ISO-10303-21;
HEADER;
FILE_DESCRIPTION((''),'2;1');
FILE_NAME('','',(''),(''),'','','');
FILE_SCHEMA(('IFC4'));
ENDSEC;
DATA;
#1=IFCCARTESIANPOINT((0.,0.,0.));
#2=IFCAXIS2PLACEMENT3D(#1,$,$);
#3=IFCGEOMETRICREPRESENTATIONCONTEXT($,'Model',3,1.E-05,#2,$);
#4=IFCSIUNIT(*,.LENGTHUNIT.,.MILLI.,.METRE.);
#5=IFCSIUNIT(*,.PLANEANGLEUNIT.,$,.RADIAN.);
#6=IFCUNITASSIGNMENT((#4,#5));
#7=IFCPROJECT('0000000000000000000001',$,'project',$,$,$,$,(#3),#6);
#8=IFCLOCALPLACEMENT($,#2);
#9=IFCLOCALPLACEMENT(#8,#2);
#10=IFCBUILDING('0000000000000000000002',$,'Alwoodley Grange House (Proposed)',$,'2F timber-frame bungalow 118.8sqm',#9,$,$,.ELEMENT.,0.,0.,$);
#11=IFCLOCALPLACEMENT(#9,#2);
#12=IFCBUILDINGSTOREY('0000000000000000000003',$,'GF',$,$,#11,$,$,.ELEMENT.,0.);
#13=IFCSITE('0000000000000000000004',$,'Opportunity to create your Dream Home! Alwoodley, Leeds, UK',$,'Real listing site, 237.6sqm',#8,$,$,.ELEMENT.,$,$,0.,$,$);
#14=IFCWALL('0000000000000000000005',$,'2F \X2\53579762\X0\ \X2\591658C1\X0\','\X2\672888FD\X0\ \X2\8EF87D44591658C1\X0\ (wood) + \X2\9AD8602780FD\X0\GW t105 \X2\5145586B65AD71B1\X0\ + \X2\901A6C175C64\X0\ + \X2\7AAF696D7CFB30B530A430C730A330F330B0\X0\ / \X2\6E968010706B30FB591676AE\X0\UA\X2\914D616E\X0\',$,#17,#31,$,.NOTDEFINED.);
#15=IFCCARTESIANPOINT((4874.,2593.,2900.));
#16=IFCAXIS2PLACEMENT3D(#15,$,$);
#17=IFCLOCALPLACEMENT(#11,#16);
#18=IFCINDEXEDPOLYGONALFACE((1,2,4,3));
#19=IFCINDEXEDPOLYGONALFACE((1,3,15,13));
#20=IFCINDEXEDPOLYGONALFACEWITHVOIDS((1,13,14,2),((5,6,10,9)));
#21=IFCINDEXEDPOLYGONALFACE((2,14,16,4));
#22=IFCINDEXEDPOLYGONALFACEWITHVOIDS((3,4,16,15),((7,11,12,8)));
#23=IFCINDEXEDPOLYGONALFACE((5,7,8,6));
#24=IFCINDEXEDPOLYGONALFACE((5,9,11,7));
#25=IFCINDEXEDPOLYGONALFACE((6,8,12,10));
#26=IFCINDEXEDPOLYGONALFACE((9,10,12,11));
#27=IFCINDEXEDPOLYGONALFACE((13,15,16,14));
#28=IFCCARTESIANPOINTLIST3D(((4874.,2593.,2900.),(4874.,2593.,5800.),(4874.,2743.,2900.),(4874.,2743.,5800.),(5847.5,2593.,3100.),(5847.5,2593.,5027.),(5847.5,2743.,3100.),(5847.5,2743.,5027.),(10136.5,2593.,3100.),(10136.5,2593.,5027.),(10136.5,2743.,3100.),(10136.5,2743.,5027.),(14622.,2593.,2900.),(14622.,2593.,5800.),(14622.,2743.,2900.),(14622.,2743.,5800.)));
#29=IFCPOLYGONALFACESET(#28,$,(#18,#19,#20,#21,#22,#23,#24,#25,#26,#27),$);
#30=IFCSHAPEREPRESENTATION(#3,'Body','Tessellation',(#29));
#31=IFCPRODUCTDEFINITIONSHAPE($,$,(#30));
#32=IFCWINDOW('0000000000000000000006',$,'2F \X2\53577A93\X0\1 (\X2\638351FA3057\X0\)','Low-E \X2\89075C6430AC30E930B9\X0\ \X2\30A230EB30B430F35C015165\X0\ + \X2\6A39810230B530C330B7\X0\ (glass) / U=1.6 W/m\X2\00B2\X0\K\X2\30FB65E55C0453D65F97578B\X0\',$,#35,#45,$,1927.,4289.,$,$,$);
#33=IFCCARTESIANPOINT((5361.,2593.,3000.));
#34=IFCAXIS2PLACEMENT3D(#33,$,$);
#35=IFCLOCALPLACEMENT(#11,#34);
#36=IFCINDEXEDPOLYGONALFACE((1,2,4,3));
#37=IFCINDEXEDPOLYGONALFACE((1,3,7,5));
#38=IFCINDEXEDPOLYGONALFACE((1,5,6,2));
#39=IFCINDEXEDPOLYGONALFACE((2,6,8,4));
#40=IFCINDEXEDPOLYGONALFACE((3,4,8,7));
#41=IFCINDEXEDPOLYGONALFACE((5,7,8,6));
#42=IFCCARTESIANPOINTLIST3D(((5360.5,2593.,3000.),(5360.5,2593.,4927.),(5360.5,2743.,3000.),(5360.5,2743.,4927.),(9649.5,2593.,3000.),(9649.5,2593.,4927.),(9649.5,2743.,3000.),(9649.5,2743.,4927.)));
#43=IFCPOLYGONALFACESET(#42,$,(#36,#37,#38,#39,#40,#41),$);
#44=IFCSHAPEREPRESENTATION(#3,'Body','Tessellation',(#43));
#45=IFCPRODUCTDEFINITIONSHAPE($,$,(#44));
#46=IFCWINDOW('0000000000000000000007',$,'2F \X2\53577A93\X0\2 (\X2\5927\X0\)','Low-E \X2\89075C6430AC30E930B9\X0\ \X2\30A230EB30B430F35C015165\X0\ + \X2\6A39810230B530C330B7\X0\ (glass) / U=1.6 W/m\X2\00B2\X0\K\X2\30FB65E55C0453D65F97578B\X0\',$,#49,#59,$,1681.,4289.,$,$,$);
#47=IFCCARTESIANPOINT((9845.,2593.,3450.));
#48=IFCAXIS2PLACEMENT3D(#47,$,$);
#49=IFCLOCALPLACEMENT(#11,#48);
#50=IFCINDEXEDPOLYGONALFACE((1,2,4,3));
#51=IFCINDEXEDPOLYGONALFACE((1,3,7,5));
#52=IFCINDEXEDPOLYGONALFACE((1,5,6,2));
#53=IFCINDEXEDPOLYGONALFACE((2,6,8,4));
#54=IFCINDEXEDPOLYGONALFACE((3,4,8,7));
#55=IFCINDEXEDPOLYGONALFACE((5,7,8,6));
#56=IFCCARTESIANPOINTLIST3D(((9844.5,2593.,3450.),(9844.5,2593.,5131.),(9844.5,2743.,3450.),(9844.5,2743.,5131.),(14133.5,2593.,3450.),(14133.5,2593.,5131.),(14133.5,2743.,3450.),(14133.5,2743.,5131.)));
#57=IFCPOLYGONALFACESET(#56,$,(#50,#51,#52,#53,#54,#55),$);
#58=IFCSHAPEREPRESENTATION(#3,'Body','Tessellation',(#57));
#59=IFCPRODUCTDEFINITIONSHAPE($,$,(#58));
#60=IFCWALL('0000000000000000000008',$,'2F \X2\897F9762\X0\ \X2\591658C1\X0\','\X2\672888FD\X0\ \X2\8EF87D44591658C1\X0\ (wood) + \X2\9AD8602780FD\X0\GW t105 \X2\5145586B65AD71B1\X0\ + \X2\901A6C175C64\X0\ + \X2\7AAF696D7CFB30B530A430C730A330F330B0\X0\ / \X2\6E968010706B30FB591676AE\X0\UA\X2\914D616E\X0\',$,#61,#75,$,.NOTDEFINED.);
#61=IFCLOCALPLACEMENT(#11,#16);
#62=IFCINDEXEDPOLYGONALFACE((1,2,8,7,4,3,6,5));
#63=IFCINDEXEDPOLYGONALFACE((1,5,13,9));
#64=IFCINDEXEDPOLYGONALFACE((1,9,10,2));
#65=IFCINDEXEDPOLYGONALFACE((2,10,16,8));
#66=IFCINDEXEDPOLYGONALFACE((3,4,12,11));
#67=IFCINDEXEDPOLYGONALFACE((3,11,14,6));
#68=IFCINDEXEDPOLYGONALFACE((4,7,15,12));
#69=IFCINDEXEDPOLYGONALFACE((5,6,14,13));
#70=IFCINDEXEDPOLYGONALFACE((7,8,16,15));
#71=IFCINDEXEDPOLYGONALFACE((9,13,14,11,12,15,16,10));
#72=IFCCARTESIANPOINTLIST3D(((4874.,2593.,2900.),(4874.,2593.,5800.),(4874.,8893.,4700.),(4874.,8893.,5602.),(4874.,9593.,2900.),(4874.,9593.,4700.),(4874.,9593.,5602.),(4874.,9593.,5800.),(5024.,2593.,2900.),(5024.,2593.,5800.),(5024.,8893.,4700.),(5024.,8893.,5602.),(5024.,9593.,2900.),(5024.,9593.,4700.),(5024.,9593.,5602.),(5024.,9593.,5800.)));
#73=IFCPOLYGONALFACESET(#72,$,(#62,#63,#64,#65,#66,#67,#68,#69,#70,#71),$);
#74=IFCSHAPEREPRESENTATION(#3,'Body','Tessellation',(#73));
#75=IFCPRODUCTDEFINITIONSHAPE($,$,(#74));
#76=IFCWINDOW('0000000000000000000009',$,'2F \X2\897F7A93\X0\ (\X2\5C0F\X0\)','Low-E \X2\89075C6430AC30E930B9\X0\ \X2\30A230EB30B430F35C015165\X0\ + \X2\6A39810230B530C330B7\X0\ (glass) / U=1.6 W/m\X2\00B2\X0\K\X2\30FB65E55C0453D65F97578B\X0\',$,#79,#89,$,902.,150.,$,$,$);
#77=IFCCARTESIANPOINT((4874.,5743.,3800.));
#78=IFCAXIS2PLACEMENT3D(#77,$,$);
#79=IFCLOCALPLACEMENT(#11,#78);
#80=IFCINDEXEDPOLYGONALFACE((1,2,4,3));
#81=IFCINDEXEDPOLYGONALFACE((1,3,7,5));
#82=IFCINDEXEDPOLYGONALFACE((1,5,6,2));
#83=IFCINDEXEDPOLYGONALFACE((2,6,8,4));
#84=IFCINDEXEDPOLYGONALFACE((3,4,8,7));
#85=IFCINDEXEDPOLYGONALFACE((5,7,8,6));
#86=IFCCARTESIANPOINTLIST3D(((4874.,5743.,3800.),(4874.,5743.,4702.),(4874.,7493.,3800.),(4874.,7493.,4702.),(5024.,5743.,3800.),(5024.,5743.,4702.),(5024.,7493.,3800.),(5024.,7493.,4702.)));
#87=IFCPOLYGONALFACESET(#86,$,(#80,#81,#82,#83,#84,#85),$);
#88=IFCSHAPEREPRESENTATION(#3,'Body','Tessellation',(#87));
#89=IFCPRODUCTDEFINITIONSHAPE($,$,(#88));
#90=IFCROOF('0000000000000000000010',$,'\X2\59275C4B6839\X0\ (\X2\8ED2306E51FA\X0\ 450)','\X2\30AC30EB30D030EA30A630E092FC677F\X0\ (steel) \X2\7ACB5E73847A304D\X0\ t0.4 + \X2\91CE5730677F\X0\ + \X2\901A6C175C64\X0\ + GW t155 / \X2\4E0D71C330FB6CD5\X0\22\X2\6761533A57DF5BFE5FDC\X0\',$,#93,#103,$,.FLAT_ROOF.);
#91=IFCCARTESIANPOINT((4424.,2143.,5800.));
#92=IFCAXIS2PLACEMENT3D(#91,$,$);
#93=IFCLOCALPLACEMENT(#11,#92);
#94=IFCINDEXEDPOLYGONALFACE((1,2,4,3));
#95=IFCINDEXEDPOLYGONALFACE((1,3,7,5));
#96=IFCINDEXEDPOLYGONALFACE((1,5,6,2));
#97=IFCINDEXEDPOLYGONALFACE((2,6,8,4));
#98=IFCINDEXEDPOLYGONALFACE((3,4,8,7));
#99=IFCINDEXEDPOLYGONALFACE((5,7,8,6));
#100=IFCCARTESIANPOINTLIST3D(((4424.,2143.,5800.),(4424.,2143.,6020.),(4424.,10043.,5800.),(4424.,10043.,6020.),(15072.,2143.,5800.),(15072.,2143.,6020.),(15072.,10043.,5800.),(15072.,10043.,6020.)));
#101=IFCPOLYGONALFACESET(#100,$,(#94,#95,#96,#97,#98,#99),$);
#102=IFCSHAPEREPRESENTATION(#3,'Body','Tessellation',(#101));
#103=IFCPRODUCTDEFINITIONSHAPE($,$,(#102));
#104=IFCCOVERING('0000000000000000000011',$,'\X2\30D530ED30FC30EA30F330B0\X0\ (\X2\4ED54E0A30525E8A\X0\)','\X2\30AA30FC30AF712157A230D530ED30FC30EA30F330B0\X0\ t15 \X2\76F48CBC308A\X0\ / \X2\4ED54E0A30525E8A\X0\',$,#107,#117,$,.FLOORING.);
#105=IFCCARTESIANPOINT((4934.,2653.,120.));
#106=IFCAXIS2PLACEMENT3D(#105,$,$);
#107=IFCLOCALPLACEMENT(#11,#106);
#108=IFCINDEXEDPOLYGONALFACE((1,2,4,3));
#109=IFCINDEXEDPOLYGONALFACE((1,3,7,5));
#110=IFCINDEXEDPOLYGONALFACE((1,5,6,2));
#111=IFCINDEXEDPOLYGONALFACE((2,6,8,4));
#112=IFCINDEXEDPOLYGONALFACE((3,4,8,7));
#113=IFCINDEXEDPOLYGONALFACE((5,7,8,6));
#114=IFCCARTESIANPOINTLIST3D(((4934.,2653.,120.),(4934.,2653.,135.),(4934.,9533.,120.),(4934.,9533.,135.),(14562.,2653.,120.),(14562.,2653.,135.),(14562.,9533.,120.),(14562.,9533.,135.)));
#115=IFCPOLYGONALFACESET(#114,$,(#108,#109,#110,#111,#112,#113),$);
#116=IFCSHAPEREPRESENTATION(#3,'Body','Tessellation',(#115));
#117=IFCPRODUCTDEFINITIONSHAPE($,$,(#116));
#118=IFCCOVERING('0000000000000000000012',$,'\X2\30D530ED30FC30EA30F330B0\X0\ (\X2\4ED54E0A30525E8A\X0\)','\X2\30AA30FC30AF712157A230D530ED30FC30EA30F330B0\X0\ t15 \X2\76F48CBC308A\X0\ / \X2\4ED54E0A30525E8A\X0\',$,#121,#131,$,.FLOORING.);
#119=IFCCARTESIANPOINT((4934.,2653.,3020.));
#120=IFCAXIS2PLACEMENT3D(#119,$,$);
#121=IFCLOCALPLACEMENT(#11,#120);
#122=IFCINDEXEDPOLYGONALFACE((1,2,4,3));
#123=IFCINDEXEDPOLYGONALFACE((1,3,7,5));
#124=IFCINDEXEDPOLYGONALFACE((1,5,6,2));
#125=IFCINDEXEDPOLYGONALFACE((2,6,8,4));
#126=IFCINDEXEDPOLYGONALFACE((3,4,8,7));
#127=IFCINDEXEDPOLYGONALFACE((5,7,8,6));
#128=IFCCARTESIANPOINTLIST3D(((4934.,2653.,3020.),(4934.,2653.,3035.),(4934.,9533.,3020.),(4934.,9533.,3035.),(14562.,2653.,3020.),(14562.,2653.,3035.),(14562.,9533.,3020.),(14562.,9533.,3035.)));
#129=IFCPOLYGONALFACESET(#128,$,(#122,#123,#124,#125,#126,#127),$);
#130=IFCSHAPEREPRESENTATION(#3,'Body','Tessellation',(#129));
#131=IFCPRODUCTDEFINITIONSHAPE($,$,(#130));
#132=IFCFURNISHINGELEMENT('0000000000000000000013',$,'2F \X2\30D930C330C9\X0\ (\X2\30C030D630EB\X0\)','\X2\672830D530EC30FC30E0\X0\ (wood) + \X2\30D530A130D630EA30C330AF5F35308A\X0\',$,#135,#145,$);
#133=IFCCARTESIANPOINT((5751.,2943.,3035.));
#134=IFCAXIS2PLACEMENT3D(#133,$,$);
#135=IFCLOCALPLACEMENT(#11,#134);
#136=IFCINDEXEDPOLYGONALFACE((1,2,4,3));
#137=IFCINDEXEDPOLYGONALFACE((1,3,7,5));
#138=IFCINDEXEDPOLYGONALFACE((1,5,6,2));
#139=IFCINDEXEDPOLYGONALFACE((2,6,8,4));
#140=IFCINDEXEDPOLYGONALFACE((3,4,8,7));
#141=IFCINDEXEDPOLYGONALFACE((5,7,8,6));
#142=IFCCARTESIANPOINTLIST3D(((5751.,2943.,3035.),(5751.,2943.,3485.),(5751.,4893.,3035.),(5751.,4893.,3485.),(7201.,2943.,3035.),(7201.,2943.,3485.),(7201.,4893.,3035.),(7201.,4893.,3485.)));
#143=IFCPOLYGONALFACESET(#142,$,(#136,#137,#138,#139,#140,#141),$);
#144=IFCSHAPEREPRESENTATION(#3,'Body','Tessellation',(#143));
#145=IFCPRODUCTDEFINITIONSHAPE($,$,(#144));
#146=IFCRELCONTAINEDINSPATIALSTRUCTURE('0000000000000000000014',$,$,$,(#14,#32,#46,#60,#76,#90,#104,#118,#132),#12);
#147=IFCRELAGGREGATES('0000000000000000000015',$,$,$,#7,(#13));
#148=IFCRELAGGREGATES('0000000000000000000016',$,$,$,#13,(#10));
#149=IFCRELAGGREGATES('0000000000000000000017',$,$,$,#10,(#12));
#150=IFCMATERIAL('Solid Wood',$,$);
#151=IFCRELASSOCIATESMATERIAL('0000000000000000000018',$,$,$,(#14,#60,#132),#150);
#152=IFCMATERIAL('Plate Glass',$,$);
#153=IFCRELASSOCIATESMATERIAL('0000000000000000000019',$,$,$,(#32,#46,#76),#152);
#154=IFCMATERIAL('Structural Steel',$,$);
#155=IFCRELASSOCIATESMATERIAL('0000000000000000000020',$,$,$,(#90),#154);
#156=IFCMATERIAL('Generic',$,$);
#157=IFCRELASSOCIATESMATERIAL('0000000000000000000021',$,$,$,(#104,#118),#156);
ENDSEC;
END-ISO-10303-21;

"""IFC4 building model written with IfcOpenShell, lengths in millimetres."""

from ifc_helpers import new_model, si_unit, frame, frame_2d, origin, place, context, project, spatial, rectangle, extrude, material, element, fill, save


model = new_model("IFC4")

# Units and contexts
model_context = context("Model", 3, precision=1e-05, world=origin())
ifc_project = project(units=[si_unit("LENGTHUNIT", "METRE", prefix="MILLI"), si_unit("PLANEANGLEUNIT", "RADIAN")], contexts=[model_context])

# Site, building, storey
site_placement = place(None, origin())
site = spatial("IfcSite", under=ifc_project, at=site_placement, Name="Opportunity to create your Dream Home! Alwoodley, Leeds, UK", ObjectType="Real listing site, 237.6sqm", CompositionType="ELEMENT", RefElevation=0.0)
building_placement = place(site_placement, origin())
building = spatial("IfcBuilding", under=site, at=building_placement, Name="Alwoodley Grange House (Proposed)", ObjectType="2F timber-frame bungalow 118.8sqm", CompositionType="ELEMENT", ElevationOfRefHeight=0.0, ElevationOfTerrain=0.0)
storey_placement = place(building_placement, origin())
storey = spatial("IfcBuildingStorey", under=building, at=storey_placement, Name="GF", CompositionType="ELEMENT", Elevation=0.0)

# Shared definitions
ifc_material_1 = material(Name="Solid Wood")

# Shared definitions
ifc_material_2 = material(Name="Plate Glass")

# Wall, openings, windows
wall_1_placement = place(storey_placement, frame((4874.0, 2593.0, 2900.0)))
wall_1 = element("IfcWall", 1, at=wall_1_placement, inside=storey, material=ifc_material_1, Name="2F 南面 外壁", Description="木製 軸組外壁 (wood) + 高性能GW t105 充填断熱 + 通気層 + 窯業系サイディング / 準耐火・外皮UA配慮", PredefinedType="NOTDEFINED", context=model_context, shape_type="SweptSolid", body=[
    extrude(rectangle(XDim=9748.0, YDim=150.0, at=frame_2d((4874.0, 75.0))), frame((4874.0, 2593.0, 2900.0)), (0.0, 0.0, 1.0), 2900.0),
])
opening_1_placement = place(storey_placement, frame((5361.0, 2593.0, 3000.0)))
opening_1 = element("IfcOpeningElement", 2, at=opening_1_placement, cuts=wall_1, PredefinedType="NOTDEFINED", context=model_context, shape_type="SweptSolid", body=[
    extrude(rectangle(XDim=4289.0, YDim=150.0, at=frame_2d((2144.0, 75.0))), frame((5361.0, 2593.0, 3000.0)), (0.0, 0.0, 1.0), 1927.0),
])
opening_2_placement = place(storey_placement, frame((9845.0, 2593.0, 3450.0)))
opening_2 = element("IfcOpeningElement", 3, at=opening_2_placement, cuts=wall_1, PredefinedType="NOTDEFINED", context=model_context, shape_type="SweptSolid", body=[
    extrude(rectangle(XDim=4289.0, YDim=150.0, at=frame_2d((2144.0, 75.0))), frame((9845.0, 2593.0, 3450.0)), (0.0, 0.0, 1.0), 1681.0),
])
window_1_placement = place(storey_placement, frame((5361.0, 2593.0, 3000.0)))
window_1 = element("IfcWindow", 4, at=window_1_placement, inside=storey, material=ifc_material_2, Name="2F 南窓1 (掃出し)", Description="Low-E 複層ガラス アルゴン封入 + 樹脂サッシ (glass) / U=1.6 W/m²K・日射取得型", OverallHeight=1927.0, OverallWidth=4289.0, context=model_context, shape_type="SweptSolid", body=[
    extrude(rectangle(XDim=4289.0, YDim=150.0, at=frame_2d((2144.0, 75.0))), frame((5361.0, 2593.0, 3000.0)), (0.0, 0.0, 1.0), 1927.0),
])
fill(opening_1, window_1)
window_2_placement = place(storey_placement, frame((9845.0, 2593.0, 3450.0)))
window_2 = element("IfcWindow", 5, at=window_2_placement, inside=storey, material=ifc_material_2, Name="2F 南窓2 (大)", Description="Low-E 複層ガラス アルゴン封入 + 樹脂サッシ (glass) / U=1.6 W/m²K・日射取得型", OverallHeight=1681.0, OverallWidth=4289.0, context=model_context, shape_type="SweptSolid", body=[
    extrude(rectangle(XDim=4289.0, YDim=150.0, at=frame_2d((2144.0, 75.0))), frame((9845.0, 2593.0, 3450.0)), (0.0, 0.0, 1.0), 1681.0),
])
fill(opening_2, window_2)

# Wall, opening, window
wall_2_placement = place(storey_placement, frame((4874.0, 2593.0, 2900.0)))
wall_2 = element("IfcWall", 6, at=wall_2_placement, inside=storey, material=ifc_material_1, Name="2F 西面 外壁", Description="木製 軸組外壁 (wood) + 高性能GW t105 充填断熱 + 通気層 + 窯業系サイディング / 準耐火・外皮UA配慮", PredefinedType="NOTDEFINED", context=model_context, shape_type="SweptSolid", body=[
    extrude(rectangle(XDim=150.0, YDim=7000.0, at=frame_2d((75.0, 3500.0))), frame((4874.0, 2593.0, 2900.0)), (0.0, 0.0, 1.0), 2900.0),
])
opening_3_placement = place(storey_placement, frame((4874.0, 5743.0, 3800.0)))
opening_3 = element("IfcOpeningElement", 7, at=opening_3_placement, cuts=wall_2, PredefinedType="NOTDEFINED", context=model_context, shape_type="SweptSolid", body=[
    extrude(rectangle(XDim=150.0, YDim=1750.0, at=frame_2d((75.0, 875.0))), frame((4874.0, 5743.0, 3800.0)), (0.0, 0.0, 1.0), 902.0),
])
window_3_placement = place(storey_placement, frame((4874.0, 5743.0, 3800.0)))
window_3 = element("IfcWindow", 8, at=window_3_placement, inside=storey, material=ifc_material_2, Name="2F 西窓 (小)", Description="Low-E 複層ガラス アルゴン封入 + 樹脂サッシ (glass) / U=1.6 W/m²K・日射取得型", OverallHeight=902.0, OverallWidth=150.0, context=model_context, shape_type="SweptSolid", body=[
    extrude(rectangle(XDim=150.0, YDim=1750.0, at=frame_2d((75.0, 875.0))), frame((4874.0, 5743.0, 3800.0)), (0.0, 0.0, 1.0), 902.0),
])
fill(opening_3, window_3)

# Roof
ifc_material_3 = material(Name="Structural Steel")
roof_placement = place(storey_placement, frame((4424.0, 2143.0, 5800.0)))
element("IfcRoof", 9, at=roof_placement, inside=storey, material=ifc_material_3, Name="大屋根 (軒の出 450)", Description="ガルバリウム鋼板 (steel) 立平葺き t0.4 + 野地板 + 通気層 + GW t155 / 不燃・法22条区域対応", PredefinedType="FLAT_ROOF", context=model_context, shape_type="SweptSolid", body=[
    extrude(rectangle(XDim=10648.0, YDim=7900.0, at=frame_2d((5324.0, 3950.0))), frame((4424.0, 2143.0, 5800.0)), (0.0, 0.0, 1.0), 220.0),
])

# Coverings
ifc_material_4 = material(Name="Generic")
covering_1_placement = place(storey_placement, frame((4934.0, 2653.0, 120.0)))
element("IfcCovering", 10, at=covering_1_placement, inside=storey, material=ifc_material_4, Name="フローリング (仕上げ床)", Description="オーク無垢フローリング t15 直貼り / 仕上げ床", PredefinedType="FLOORING", context=model_context, shape_type="SweptSolid", body=[
    extrude(rectangle(XDim=9628.0, YDim=6880.0, at=frame_2d((4814.0, 3440.0))), frame((4934.0, 2653.0, 120.0)), (0.0, 0.0, 1.0), 15.0),
])
covering_2_placement = place(storey_placement, frame((4934.0, 2653.0, 3020.0)))
element("IfcCovering", 11, at=covering_2_placement, inside=storey, material=ifc_material_4, Name="フローリング (仕上げ床)", Description="オーク無垢フローリング t15 直貼り / 仕上げ床", PredefinedType="FLOORING", context=model_context, shape_type="SweptSolid", body=[
    extrude(rectangle(XDim=9628.0, YDim=6880.0, at=frame_2d((4814.0, 3440.0))), frame((4934.0, 2653.0, 3020.0)), (0.0, 0.0, 1.0), 15.0),
])

# Furnishing element
furnishing_placement = place(storey_placement, frame((5751.0, 2943.0, 3035.0)))
element("IfcFurnishingElement", 12, at=furnishing_placement, inside=storey, material=ifc_material_1, Name="2F ベッド (ダブル)", Description="木フレーム (wood) + ファブリック張り", context=model_context, shape_type="SweptSolid", body=[
    extrude(rectangle(XDim=1450.0, YDim=1950.0, at=frame_2d((725.0, 975.0))), frame((5751.0, 2943.0, 3035.0)), (0.0, 0.0, 1.0), 450.0),
])

save(model, "model.ifc")
